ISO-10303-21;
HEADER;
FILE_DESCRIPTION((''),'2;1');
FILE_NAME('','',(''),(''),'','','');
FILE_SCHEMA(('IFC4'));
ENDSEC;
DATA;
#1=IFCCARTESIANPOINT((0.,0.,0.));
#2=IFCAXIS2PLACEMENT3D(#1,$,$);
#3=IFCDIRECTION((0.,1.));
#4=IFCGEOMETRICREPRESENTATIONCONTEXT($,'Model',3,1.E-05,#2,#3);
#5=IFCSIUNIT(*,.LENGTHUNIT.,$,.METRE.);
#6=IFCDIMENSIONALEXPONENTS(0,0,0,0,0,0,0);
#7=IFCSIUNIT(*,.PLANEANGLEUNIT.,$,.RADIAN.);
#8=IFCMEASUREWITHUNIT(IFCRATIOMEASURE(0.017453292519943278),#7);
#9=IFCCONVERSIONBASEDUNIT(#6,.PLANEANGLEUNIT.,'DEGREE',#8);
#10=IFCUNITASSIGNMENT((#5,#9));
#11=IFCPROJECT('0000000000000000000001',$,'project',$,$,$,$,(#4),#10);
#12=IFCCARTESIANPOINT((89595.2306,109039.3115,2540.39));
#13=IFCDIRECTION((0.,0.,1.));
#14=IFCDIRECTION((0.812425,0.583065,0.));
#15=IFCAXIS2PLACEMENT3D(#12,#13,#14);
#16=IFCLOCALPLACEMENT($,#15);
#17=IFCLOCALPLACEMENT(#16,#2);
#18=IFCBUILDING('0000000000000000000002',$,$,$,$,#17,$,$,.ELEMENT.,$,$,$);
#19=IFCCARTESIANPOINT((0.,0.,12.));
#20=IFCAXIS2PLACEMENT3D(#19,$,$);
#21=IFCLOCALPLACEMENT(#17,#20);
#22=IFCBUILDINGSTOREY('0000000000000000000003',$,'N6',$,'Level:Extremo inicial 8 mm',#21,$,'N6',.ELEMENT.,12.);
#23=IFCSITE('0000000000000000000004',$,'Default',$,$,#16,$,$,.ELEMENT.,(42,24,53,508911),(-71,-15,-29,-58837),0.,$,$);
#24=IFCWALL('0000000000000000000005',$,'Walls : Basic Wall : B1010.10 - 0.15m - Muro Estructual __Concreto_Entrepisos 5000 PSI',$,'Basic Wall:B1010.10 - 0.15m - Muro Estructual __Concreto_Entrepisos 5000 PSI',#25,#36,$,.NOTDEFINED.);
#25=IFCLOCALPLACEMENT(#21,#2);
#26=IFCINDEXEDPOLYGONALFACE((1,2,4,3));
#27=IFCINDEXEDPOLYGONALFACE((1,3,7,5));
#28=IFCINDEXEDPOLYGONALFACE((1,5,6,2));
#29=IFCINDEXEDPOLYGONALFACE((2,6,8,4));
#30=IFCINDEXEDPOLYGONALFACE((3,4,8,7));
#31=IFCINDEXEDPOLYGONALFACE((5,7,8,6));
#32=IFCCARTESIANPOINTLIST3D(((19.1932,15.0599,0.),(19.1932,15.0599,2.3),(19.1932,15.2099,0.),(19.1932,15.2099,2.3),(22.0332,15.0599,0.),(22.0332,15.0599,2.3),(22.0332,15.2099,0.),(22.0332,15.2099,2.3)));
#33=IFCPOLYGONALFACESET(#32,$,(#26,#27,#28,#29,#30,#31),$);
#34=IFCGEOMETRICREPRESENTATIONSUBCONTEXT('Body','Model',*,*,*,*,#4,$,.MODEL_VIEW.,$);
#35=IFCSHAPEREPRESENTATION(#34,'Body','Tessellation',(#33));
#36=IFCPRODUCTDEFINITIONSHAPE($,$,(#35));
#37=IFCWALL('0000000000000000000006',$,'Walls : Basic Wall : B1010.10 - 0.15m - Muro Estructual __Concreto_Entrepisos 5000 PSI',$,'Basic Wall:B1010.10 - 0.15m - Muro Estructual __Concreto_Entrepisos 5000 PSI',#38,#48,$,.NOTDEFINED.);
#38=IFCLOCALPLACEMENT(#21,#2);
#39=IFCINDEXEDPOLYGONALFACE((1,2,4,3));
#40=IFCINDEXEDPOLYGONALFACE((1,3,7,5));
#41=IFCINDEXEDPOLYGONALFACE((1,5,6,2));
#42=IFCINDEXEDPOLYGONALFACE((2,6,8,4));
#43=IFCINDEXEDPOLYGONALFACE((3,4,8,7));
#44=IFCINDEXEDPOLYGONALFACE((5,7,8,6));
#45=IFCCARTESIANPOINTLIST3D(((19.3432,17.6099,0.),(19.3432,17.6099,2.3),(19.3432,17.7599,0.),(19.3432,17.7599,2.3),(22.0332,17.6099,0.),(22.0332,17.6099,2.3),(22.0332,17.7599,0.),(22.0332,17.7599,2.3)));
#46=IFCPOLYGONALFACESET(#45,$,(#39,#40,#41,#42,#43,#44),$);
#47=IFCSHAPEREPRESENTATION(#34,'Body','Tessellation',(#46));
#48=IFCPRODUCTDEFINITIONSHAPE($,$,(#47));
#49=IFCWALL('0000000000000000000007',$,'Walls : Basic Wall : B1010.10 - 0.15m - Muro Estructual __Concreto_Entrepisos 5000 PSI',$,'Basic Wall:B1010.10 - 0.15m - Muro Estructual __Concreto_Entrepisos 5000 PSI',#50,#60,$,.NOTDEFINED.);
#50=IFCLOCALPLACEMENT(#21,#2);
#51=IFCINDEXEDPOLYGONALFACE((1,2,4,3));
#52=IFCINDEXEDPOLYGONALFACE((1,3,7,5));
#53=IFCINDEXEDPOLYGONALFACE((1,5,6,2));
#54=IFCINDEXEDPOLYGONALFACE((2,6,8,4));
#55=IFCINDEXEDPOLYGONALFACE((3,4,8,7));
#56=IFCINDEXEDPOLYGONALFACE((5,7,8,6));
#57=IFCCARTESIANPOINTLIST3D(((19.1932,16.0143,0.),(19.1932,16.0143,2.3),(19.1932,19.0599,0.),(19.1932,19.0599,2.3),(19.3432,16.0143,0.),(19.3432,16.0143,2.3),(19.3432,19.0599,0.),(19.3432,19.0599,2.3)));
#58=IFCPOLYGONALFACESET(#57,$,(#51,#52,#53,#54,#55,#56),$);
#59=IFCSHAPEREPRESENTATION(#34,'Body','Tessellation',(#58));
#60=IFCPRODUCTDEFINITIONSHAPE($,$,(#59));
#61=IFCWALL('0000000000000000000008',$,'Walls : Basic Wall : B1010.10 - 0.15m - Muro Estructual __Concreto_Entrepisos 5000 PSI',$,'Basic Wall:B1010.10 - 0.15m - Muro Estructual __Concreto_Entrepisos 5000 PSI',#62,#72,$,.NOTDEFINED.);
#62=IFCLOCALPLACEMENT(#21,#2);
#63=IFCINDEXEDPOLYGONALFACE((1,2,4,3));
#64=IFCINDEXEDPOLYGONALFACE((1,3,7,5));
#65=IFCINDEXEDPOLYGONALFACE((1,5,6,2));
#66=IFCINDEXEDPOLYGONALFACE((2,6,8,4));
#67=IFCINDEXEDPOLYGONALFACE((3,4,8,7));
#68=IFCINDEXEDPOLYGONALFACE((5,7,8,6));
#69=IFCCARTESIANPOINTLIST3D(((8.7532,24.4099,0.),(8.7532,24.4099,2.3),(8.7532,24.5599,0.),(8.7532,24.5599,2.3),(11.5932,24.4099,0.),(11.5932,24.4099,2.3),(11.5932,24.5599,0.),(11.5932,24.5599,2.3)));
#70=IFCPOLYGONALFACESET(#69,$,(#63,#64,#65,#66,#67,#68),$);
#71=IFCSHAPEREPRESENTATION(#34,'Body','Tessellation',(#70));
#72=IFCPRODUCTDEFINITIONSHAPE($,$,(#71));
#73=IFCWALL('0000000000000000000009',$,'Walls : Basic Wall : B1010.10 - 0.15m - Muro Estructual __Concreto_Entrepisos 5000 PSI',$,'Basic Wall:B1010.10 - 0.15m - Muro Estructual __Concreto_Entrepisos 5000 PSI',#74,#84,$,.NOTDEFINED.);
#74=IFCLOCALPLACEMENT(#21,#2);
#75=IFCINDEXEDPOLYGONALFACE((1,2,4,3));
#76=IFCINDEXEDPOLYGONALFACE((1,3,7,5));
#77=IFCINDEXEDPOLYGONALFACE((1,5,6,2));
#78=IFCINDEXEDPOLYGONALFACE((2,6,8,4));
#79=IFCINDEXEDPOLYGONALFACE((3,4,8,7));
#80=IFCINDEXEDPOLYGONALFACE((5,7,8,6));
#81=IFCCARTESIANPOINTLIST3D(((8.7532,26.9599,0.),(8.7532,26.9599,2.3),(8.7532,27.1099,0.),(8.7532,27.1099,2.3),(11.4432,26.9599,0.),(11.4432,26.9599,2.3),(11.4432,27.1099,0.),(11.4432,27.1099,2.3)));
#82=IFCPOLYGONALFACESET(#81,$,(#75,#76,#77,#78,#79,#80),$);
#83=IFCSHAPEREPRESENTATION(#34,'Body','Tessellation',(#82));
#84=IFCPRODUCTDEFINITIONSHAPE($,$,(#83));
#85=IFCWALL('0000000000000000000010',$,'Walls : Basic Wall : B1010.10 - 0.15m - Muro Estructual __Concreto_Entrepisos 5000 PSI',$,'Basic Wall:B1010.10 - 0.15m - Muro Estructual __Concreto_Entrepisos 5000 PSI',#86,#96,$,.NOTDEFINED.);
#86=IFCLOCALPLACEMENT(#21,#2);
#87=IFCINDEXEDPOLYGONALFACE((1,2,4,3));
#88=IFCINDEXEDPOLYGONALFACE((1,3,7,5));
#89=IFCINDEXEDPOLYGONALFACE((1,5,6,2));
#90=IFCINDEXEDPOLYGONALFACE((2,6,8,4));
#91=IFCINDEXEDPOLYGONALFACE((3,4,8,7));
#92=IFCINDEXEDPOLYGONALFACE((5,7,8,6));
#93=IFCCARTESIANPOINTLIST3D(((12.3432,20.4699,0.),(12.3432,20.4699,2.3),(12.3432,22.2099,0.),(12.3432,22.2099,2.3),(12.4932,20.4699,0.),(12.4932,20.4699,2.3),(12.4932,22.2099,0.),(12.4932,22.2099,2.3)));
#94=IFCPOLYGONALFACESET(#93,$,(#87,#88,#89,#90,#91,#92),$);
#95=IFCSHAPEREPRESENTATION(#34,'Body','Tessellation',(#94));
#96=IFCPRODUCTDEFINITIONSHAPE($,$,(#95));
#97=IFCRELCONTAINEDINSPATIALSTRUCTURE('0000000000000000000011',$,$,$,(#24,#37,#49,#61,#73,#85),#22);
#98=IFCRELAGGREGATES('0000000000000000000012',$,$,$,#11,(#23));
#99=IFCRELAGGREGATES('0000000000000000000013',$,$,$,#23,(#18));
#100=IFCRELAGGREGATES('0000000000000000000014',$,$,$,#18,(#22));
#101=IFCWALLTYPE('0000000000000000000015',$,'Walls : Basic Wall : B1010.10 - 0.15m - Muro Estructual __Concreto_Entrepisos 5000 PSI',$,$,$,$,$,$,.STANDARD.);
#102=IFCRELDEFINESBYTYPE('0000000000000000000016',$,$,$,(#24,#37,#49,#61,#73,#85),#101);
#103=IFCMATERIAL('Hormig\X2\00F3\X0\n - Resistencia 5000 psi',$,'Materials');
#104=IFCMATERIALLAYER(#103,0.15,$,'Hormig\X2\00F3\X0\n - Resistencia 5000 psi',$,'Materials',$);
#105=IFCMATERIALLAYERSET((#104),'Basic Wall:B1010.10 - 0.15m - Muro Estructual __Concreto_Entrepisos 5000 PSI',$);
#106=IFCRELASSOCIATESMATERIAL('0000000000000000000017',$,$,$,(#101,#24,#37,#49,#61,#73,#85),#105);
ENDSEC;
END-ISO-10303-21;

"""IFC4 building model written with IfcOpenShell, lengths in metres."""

from ifc_helpers import new_model, entity, si_unit, converted_unit, direction, frame, frame_2d, origin, place, context, subcontext, project, spatial, rectangle, extrude, material, layer, layer_set, layer_usage, type_object, element, save


model = new_model("IFC4")

# Units and contexts
model_context = context("Model", 3, precision=1e-05, world=origin(), true_north=direction((0.0, 1.0)))
body_context = subcontext(model_context, "Body", "Model", "MODEL_VIEW")
ifc_project = project(units=[si_unit("LENGTHUNIT", "METRE"), converted_unit("PLANEANGLEUNIT", "DEGREE", entity("IfcRatioMeasure", 0.017453292519943278), si_unit("PLANEANGLEUNIT", "RADIAN"), dimensions=[0, 0, 0, 0, 0, 0, 0])], contexts=[model_context])

# Site, building, storey
site_placement = place(None, frame((89595.2306, 109039.3115, 2540.39), z_axis=(0.0, 0.0, 1.0), x_axis=(0.812425, 0.583065, 0.0)))
site = spatial("IfcSite", under=ifc_project, at=site_placement, Name="Default", CompositionType="ELEMENT", RefLatitude=(42, 24, 53, 508911), RefLongitude=(-71, -15, -29, -58837), RefElevation=0.0)
building_placement = place(site_placement, origin())
building = spatial("IfcBuilding", under=site, at=building_placement, CompositionType="ELEMENT")
storey_placement = place(building_placement, frame((0.0, 0.0, 12.0)))
storey = spatial("IfcBuildingStorey", under=building, at=storey_placement, Name="N6", ObjectType="Level:Extremo inicial 8 mm", LongName="N6", CompositionType="ELEMENT", Elevation=12.0)

# Walls
ifc_material = material(Name="Hormigón - Resistencia 5000 psi", Category="Materials")
ifc_layer_1 = layer(ifc_material, 0.15, Name="Hormigón - Resistencia 5000 psi", Category="Materials")
ifc_layer_set_1 = layer_set([ifc_layer_1], Name="Basic Wall:B1010.10 - 0.15m - Muro Estructual __Concreto_Entrepisos 5000 PSI")
ifc_layer_usage_1 = layer_usage(ifc_layer_set_1, "AXIS2", "NEGATIVE", 0.075)
wall_type_1 = type_object("IfcWallType", Name="Walls : Basic Wall : B1010.10 - 0.15m - Muro Estructual __Concreto_Entrepisos 5000 PSI", PredefinedType="STANDARD", material=ifc_layer_set_1)
wall_1_placement = place(storey_placement, frame((22.0332, 15.1349, 0.0), z_axis=(0.0, 0.0, 1.0), x_axis=(-1.0, 0.0, 0.0)))
element("IfcWall", 1, at=wall_1_placement, inside=storey, type_object=wall_type_1, material=ifc_layer_usage_1, Name="Walls : Basic Wall : B1010.10 - 0.15m - Muro Estructual __Concreto_Entrepisos 5000 PSI", ObjectType="Basic Wall:B1010.10 - 0.15m - Muro Estructual __Concreto_Entrepisos 5000 PSI", PredefinedType="NOTDEFINED", context=body_context, shape_type="SweptSolid", body=[
    extrude(rectangle(XDim=2.84, YDim=0.15, at=frame_2d((1.42, 0.0), x_axis=(-1.0, 0.0))), origin(), (0.0, 0.0, 1.0), 2.3),
])
ifc_layer_usage_2 = layer_usage(ifc_layer_set_1, "AXIS2", "NEGATIVE", 0.075)
wall_2_placement = place(storey_placement, frame((22.0332, 17.6849, 0.0), z_axis=(0.0, 0.0, 1.0), x_axis=(-1.0, 0.0, 0.0)))
element("IfcWall", 2, at=wall_2_placement, inside=storey, type_object=wall_type_1, material=ifc_layer_usage_2, Name="Walls : Basic Wall : B1010.10 - 0.15m - Muro Estructual __Concreto_Entrepisos 5000 PSI", ObjectType="Basic Wall:B1010.10 - 0.15m - Muro Estructual __Concreto_Entrepisos 5000 PSI", PredefinedType="NOTDEFINED", context=body_context, shape_type="SweptSolid", body=[
    extrude(rectangle(XDim=2.69, YDim=0.15, at=frame_2d((1.345, 0.0), x_axis=(-1.0, 0.0))), origin(), (0.0, 0.0, 1.0), 2.3),
])
ifc_layer_usage_3 = layer_usage(ifc_layer_set_1, "AXIS2", "NEGATIVE", 0.075)
wall_3_placement = place(storey_placement, frame((19.2682, 16.0143, 0.0), z_axis=(0.0, 0.0, 1.0), x_axis=(0.0, 1.0, 0.0)))
element("IfcWall", 3, at=wall_3_placement, inside=storey, type_object=wall_type_1, material=ifc_layer_usage_3, Name="Walls : Basic Wall : B1010.10 - 0.15m - Muro Estructual __Concreto_Entrepisos 5000 PSI", ObjectType="Basic Wall:B1010.10 - 0.15m - Muro Estructual __Concreto_Entrepisos 5000 PSI", PredefinedType="NOTDEFINED", context=body_context, shape_type="SweptSolid", body=[
    extrude(rectangle(XDim=3.0455, YDim=0.15, at=frame_2d((1.5228, 0.0), x_axis=(-1.0, 0.0))), origin(), (0.0, 0.0, 1.0), 2.3),
])
ifc_layer_usage_4 = layer_usage(ifc_layer_set_1, "AXIS2", "NEGATIVE", 0.075)
wall_4_placement = place(storey_placement, frame((8.7532, 24.4849, 0.0)))
element("IfcWall", 4, at=wall_4_placement, inside=storey, type_object=wall_type_1, material=ifc_layer_usage_4, Name="Walls : Basic Wall : B1010.10 - 0.15m - Muro Estructual __Concreto_Entrepisos 5000 PSI", ObjectType="Basic Wall:B1010.10 - 0.15m - Muro Estructual __Concreto_Entrepisos 5000 PSI", PredefinedType="NOTDEFINED", context=body_context, shape_type="SweptSolid", body=[
    extrude(rectangle(XDim=2.84, YDim=0.15, at=frame_2d((1.42, 0.0), x_axis=(-1.0, 0.0))), origin(), (0.0, 0.0, 1.0), 2.3),
])
ifc_layer_usage_5 = layer_usage(ifc_layer_set_1, "AXIS2", "NEGATIVE", 0.075)
wall_5_placement = place(storey_placement, frame((8.7532, 27.0349, 0.0)))
element("IfcWall", 5, at=wall_5_placement, inside=storey, type_object=wall_type_1, material=ifc_layer_usage_5, Name="Walls : Basic Wall : B1010.10 - 0.15m - Muro Estructual __Concreto_Entrepisos 5000 PSI", ObjectType="Basic Wall:B1010.10 - 0.15m - Muro Estructual __Concreto_Entrepisos 5000 PSI", PredefinedType="NOTDEFINED", context=body_context, shape_type="SweptSolid", body=[
    extrude(rectangle(XDim=2.69, YDim=0.15, at=frame_2d((1.345, 0.0), x_axis=(-1.0, 0.0))), origin(), (0.0, 0.0, 1.0), 2.3),
])
ifc_layer_usage_6 = layer_usage(ifc_layer_set_1, "AXIS2", "POSITIVE", -0.075)
wall_6_placement = place(storey_placement, frame((12.4182, 20.4699, 0.0), z_axis=(0.0, 0.0, 1.0), x_axis=(0.0, 1.0, 0.0)))
element("IfcWall", 6, at=wall_6_placement, inside=storey, type_object=wall_type_1, material=ifc_layer_usage_6, Name="Walls : Basic Wall : B1010.10 - 0.15m - Muro Estructual __Concreto_Entrepisos 5000 PSI", ObjectType="Basic Wall:B1010.10 - 0.15m - Muro Estructual __Concreto_Entrepisos 5000 PSI", PredefinedType="NOTDEFINED", context=body_context, shape_type="SweptSolid", body=[
    extrude(rectangle(XDim=1.74, YDim=0.15, at=frame_2d((0.87, 0.0), x_axis=(-1.0, 0.0))), origin(), (0.0, 0.0, 1.0), 2.3),
])

save(model, "model.ifc")
